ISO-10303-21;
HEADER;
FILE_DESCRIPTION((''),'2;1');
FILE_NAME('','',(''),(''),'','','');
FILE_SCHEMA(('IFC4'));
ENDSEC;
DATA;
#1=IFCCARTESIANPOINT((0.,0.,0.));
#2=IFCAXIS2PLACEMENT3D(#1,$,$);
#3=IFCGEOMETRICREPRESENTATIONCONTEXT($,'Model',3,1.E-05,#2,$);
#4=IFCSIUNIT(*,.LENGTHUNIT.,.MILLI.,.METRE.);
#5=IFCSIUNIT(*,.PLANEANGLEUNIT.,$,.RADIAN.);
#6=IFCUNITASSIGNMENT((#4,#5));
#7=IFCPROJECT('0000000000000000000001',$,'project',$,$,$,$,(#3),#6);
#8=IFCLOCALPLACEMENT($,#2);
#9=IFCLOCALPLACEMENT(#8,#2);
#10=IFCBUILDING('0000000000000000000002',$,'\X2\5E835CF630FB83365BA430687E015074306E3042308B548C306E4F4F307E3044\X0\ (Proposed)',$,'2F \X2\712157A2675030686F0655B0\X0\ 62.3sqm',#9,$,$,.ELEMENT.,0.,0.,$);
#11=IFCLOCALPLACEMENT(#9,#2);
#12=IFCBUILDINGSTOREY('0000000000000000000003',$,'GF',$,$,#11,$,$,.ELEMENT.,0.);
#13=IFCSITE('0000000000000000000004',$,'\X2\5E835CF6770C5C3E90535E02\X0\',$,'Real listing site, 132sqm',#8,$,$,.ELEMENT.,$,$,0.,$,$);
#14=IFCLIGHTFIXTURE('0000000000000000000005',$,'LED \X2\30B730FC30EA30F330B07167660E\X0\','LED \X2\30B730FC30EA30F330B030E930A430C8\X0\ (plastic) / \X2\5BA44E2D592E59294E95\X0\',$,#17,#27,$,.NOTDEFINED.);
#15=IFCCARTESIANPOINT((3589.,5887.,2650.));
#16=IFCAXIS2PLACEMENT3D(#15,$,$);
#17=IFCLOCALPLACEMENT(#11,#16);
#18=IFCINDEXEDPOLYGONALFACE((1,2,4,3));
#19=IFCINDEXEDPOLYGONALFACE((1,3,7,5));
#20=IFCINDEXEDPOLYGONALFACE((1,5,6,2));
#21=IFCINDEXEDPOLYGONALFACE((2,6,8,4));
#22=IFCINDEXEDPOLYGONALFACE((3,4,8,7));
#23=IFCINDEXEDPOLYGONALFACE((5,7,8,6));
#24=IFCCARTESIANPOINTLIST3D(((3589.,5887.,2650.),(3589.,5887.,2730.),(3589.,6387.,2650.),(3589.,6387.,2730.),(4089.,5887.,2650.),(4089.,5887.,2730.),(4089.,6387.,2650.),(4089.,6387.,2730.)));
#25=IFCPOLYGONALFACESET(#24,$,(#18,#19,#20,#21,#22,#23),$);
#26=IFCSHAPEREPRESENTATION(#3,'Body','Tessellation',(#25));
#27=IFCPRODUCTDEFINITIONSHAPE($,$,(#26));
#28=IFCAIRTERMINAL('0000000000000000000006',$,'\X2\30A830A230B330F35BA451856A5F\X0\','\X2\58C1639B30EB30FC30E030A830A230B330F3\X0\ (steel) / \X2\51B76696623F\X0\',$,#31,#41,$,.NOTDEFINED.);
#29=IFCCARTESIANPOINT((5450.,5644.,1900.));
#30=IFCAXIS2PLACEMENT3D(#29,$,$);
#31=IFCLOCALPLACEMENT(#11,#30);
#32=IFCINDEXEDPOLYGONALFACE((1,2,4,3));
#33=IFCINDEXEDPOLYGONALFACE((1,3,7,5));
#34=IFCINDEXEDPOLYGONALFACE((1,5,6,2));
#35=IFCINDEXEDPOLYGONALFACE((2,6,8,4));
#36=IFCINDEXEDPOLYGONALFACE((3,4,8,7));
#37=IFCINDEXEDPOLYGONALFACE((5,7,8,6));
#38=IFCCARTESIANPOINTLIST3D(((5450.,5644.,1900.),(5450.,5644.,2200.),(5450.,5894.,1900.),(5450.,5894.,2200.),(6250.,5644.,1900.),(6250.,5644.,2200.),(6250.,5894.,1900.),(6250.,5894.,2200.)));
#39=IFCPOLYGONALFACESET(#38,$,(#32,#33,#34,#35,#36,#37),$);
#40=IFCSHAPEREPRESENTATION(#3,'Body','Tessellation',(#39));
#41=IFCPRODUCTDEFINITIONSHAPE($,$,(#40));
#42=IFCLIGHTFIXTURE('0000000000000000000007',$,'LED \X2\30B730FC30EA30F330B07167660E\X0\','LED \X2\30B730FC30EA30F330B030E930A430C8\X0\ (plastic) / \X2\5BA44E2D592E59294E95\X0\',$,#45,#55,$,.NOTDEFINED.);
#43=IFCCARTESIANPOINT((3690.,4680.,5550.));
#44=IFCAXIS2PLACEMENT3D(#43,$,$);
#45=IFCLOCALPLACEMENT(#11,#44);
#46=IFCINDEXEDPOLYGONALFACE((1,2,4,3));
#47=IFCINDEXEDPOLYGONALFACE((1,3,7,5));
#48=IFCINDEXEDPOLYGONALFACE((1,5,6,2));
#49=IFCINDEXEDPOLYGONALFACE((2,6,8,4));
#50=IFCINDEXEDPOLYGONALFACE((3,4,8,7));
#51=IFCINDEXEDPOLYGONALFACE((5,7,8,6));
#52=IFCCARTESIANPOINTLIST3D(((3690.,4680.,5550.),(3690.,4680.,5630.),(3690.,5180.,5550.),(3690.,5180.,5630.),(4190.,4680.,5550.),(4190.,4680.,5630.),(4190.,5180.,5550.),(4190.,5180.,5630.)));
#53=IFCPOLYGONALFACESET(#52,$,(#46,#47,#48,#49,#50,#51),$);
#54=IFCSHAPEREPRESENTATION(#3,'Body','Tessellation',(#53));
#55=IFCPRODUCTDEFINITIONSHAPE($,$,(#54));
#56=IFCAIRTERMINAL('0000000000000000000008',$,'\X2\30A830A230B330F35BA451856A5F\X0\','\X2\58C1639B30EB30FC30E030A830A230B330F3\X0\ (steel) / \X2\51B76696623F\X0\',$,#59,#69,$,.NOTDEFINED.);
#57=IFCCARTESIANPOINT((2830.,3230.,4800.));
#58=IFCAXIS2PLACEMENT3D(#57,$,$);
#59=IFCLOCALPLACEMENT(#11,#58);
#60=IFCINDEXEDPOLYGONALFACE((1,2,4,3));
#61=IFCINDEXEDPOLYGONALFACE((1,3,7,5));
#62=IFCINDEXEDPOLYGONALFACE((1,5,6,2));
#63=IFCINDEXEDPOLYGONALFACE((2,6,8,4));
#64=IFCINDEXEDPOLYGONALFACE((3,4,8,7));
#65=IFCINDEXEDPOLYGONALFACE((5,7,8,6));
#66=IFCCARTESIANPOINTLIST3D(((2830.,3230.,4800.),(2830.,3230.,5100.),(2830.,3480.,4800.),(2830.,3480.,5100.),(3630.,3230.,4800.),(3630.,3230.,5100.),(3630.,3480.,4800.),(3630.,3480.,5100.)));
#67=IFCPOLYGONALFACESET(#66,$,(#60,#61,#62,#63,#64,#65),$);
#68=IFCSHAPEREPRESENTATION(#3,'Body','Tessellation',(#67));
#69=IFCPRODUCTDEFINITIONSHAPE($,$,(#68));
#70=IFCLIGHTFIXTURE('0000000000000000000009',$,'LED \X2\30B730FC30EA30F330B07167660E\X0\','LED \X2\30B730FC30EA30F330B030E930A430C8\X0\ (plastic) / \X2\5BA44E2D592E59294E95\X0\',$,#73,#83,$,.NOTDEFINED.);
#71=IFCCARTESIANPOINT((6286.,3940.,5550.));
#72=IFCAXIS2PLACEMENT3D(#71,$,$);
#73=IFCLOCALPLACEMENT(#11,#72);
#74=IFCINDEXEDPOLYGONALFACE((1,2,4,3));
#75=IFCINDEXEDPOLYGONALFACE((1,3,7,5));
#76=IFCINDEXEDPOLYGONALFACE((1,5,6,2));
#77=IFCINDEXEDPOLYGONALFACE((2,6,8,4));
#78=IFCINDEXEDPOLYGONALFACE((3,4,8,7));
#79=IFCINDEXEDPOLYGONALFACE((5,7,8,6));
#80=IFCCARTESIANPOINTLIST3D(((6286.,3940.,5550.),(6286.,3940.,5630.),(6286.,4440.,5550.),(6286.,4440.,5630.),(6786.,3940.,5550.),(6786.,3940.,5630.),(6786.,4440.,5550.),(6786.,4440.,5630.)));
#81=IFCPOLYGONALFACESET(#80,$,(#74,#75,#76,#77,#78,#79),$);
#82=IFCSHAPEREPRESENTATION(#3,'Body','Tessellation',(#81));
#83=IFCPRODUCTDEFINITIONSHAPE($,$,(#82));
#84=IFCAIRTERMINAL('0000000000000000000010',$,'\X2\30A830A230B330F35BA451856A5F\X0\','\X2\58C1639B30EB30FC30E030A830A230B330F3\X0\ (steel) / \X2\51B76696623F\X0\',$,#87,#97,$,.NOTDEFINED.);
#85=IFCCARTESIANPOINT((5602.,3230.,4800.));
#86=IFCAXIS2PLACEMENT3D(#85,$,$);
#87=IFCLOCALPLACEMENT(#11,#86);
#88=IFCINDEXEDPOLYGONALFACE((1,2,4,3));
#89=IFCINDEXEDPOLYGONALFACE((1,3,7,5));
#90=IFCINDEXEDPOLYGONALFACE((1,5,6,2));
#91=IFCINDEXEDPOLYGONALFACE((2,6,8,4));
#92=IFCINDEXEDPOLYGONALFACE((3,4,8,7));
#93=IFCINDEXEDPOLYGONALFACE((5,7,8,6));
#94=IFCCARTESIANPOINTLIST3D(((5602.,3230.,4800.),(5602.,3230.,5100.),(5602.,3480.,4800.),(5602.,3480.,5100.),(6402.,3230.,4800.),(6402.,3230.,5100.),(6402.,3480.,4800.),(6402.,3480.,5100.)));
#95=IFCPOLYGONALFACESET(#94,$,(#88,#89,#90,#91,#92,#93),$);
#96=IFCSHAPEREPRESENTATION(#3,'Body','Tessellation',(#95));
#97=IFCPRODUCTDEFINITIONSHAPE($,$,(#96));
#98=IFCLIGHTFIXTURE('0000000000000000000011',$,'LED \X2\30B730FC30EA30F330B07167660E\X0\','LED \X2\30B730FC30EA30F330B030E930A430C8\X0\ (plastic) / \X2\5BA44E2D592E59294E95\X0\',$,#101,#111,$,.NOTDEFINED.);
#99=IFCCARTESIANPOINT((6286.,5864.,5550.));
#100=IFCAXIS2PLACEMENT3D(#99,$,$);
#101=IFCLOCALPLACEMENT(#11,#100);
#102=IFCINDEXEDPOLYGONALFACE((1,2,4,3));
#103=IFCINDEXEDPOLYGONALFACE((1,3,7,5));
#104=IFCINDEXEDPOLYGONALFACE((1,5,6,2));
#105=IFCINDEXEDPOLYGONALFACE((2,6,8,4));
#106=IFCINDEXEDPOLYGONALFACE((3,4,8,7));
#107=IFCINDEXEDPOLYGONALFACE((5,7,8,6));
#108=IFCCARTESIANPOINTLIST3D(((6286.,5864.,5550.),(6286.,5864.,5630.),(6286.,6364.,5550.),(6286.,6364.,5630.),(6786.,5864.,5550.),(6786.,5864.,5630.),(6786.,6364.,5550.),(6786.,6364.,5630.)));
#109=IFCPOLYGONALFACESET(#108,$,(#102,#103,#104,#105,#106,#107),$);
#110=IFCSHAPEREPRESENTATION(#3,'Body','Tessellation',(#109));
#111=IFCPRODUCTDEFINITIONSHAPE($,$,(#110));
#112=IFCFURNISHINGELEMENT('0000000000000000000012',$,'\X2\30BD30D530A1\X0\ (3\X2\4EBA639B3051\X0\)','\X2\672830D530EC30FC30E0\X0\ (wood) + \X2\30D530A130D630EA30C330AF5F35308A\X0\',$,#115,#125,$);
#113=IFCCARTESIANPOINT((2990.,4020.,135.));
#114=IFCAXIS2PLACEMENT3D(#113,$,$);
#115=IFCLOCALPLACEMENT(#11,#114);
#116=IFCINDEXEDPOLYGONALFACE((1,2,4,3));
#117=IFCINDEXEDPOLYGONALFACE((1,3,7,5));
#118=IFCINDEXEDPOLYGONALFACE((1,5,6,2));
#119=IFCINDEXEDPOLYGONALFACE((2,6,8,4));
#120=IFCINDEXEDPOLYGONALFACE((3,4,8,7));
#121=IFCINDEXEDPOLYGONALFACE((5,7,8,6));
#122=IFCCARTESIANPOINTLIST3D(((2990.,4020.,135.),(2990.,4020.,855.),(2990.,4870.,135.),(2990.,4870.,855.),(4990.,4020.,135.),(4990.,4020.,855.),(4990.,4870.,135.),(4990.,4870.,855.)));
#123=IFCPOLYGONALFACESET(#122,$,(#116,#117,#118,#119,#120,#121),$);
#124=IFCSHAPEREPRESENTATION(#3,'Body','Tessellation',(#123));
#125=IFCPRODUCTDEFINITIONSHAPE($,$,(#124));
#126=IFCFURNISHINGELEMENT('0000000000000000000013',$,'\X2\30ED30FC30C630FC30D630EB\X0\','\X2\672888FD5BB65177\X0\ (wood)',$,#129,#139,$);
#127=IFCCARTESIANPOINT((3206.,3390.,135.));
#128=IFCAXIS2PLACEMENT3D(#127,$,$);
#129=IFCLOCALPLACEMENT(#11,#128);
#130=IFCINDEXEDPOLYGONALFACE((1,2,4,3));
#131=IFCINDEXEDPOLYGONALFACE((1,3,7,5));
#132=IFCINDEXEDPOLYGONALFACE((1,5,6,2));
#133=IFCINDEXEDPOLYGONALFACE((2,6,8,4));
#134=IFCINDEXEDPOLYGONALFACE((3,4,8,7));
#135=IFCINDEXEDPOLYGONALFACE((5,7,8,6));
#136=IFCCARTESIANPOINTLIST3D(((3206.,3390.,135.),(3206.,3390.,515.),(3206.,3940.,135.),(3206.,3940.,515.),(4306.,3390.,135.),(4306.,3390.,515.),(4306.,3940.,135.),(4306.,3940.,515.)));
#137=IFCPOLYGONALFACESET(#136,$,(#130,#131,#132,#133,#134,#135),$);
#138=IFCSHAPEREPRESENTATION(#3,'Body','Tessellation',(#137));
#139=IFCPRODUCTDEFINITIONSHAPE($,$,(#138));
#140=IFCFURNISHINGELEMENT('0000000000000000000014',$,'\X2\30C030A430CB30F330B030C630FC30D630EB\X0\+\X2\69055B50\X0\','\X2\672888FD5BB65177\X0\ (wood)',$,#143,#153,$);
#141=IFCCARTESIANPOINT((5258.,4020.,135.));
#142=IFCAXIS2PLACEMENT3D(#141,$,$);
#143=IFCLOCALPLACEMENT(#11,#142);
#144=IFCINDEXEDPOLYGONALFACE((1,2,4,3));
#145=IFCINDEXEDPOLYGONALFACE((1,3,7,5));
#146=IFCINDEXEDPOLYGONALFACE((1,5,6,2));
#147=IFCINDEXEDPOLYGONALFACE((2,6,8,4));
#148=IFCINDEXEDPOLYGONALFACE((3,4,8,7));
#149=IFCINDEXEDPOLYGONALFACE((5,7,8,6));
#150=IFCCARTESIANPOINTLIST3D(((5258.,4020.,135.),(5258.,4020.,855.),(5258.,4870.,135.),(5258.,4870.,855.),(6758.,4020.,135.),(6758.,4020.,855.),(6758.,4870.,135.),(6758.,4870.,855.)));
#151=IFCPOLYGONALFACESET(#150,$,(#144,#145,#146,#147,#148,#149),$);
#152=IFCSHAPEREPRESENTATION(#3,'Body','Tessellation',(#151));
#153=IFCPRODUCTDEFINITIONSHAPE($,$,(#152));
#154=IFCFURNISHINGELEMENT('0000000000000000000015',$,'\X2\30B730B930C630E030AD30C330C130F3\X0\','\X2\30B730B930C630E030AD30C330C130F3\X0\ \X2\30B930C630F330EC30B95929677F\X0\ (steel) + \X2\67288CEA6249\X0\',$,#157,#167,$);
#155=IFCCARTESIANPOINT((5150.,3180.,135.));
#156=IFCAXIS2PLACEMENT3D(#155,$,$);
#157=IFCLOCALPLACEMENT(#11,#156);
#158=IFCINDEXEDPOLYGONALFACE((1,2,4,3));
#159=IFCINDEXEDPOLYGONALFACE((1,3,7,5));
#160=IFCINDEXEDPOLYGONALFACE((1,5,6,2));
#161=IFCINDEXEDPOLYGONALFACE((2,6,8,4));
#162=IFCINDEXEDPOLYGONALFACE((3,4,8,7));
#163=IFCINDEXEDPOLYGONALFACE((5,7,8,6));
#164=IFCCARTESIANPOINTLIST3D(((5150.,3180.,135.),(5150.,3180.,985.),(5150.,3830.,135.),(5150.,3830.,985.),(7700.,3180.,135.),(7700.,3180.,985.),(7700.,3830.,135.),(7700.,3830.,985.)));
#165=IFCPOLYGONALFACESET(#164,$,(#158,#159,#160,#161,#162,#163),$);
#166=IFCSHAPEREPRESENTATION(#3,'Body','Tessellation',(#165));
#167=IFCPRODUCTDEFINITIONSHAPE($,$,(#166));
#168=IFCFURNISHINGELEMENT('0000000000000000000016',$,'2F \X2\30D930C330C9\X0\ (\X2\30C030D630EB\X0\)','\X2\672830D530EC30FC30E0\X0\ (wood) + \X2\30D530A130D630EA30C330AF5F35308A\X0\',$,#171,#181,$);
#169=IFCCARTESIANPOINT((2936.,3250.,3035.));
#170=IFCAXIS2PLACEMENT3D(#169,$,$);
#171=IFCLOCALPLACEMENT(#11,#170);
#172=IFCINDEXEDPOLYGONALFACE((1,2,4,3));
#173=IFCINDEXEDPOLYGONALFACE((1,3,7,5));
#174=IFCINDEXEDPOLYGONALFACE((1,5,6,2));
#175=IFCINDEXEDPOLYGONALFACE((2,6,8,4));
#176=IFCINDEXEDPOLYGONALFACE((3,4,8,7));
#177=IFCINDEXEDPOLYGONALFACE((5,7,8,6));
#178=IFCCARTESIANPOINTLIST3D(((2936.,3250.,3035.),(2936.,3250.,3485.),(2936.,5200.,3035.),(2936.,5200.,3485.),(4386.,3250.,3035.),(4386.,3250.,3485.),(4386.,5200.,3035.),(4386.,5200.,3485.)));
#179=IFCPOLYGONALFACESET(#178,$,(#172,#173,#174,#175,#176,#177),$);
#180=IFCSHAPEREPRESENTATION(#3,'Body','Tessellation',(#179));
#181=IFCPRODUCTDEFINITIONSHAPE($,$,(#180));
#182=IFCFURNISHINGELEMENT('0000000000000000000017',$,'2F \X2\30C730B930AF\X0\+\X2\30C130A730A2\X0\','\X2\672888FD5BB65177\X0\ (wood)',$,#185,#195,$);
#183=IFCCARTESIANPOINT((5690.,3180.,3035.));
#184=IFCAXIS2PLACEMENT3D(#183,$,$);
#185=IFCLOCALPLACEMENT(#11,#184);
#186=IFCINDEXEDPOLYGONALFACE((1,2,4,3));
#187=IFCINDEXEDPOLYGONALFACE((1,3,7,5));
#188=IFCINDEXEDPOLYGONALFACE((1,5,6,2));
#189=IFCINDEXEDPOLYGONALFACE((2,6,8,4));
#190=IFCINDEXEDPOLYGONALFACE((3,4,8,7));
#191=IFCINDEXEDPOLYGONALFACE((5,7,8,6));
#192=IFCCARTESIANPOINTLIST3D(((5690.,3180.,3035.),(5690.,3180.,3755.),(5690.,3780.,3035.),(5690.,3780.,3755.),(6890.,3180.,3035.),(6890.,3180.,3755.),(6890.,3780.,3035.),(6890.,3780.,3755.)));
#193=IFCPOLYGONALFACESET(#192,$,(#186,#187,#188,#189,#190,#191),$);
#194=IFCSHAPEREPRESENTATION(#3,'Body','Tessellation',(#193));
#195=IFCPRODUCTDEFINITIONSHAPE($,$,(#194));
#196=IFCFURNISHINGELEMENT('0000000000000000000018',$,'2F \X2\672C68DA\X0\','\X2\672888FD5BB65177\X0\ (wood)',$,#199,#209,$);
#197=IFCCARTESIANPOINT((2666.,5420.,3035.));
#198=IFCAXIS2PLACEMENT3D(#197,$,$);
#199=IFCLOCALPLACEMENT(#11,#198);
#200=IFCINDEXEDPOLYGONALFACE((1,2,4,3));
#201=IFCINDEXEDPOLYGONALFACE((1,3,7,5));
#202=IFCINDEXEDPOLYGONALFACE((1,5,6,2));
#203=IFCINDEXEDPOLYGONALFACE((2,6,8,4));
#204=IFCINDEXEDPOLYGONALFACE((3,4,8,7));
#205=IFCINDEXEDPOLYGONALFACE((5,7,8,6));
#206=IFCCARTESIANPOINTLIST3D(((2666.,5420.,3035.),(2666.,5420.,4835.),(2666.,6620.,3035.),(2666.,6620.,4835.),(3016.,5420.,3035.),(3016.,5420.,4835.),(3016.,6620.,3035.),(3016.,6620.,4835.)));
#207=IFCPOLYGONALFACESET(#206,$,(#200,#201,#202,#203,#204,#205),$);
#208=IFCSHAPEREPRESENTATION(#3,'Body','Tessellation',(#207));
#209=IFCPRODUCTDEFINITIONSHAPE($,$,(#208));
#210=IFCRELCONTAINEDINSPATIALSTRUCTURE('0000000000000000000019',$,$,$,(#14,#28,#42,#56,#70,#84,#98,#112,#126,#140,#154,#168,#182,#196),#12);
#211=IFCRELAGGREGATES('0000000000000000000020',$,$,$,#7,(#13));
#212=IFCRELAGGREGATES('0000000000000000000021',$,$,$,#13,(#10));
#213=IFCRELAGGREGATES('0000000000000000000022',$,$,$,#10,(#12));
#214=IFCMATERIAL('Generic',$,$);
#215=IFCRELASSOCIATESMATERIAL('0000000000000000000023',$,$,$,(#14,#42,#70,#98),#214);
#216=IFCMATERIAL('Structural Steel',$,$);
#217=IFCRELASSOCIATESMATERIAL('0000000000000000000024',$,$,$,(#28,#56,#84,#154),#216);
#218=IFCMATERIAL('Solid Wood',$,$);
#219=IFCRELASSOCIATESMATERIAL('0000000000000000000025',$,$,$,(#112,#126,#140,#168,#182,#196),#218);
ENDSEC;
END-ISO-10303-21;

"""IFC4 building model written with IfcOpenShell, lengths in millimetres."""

from ifc_helpers import new_model, si_unit, frame, frame_2d, origin, place, context, project, spatial, rectangle, extrude, material, element, save


model = new_model("IFC4")

# Units and contexts
model_context = context("Model", 3, precision=1e-05, world=origin())
ifc_project = project(units=[si_unit("LENGTHUNIT", "METRE", prefix="MILLI"), si_unit("PLANEANGLEUNIT", "RADIAN")], contexts=[model_context])

# Site, building, storey
site_placement = place(None, origin())
site = spatial("IfcSite", under=ifc_project, at=site_placement, Name="広島県尾道市", ObjectType="Real listing site, 132sqm", CompositionType="ELEMENT", RefElevation=0.0)
building_placement = place(site_placement, origin())
building = spatial("IfcBuilding", under=site, at=building_placement, Name="広島・茶室と縁側のある和の住まい (Proposed)", ObjectType="2F 無垢材と漆喰 62.3sqm", CompositionType="ELEMENT", ElevationOfRefHeight=0.0, ElevationOfTerrain=0.0)
storey_placement = place(building_placement, origin())
storey = spatial("IfcBuildingStorey", under=building, at=storey_placement, Name="GF", CompositionType="ELEMENT", Elevation=0.0)

# Shared definitions
ifc_material_1 = material(Name="Solid Wood")

# Shared definitions
ifc_material_2 = material(Name="Structural Steel")

# Shared definitions
ifc_material_3 = material(Name="Generic")

# Light fixture
light_fixture_1_placement = place(storey_placement, frame((3589.0, 5887.0, 2650.0)))
element("IfcLightFixture", 1, at=light_fixture_1_placement, inside=storey, material=ifc_material_3, Name="LED シーリング照明", Description="LED シーリングライト (plastic) / 室中央天井", PredefinedType="NOTDEFINED", context=model_context, shape_type="SweptSolid", body=[
    extrude(rectangle(XDim=500.0, YDim=500.0, at=frame_2d((250.0, 250.0))), frame((3589.0, 5887.0, 2650.0)), (0.0, 0.0, 1.0), 80.0),
])

# Air terminal
air_terminal_1_placement = place(storey_placement, frame((5450.0, 5644.0, 1900.0)))
element("IfcAirTerminal", 2, at=air_terminal_1_placement, inside=storey, material=ifc_material_2, Name="エアコン室内機", Description="壁掛ルームエアコン (steel) / 冷暖房", PredefinedType="NOTDEFINED", context=model_context, shape_type="SweptSolid", body=[
    extrude(rectangle(XDim=800.0, YDim=250.0, at=frame_2d((400.0, 125.0))), frame((5450.0, 5644.0, 1900.0)), (0.0, 0.0, 1.0), 300.0),
])

# Light fixture
light_fixture_2_placement = place(storey_placement, frame((3690.0, 4680.0, 5550.0)))
element("IfcLightFixture", 3, at=light_fixture_2_placement, inside=storey, material=ifc_material_3, Name="LED シーリング照明", Description="LED シーリングライト (plastic) / 室中央天井", PredefinedType="NOTDEFINED", context=model_context, shape_type="SweptSolid", body=[
    extrude(rectangle(XDim=500.0, YDim=500.0, at=frame_2d((250.0, 250.0))), frame((3690.0, 4680.0, 5550.0)), (0.0, 0.0, 1.0), 80.0),
])

# Air terminal
air_terminal_2_placement = place(storey_placement, frame((2830.0, 3230.0, 4800.0)))
element("IfcAirTerminal", 4, at=air_terminal_2_placement, inside=storey, material=ifc_material_2, Name="エアコン室内機", Description="壁掛ルームエアコン (steel) / 冷暖房", PredefinedType="NOTDEFINED", context=model_context, shape_type="SweptSolid", body=[
    extrude(rectangle(XDim=800.0, YDim=250.0, at=frame_2d((400.0, 125.0))), frame((2830.0, 3230.0, 4800.0)), (0.0, 0.0, 1.0), 300.0),
])

# Light fixture
light_fixture_3_placement = place(storey_placement, frame((6286.0, 3940.0, 5550.0)))
element("IfcLightFixture", 5, at=light_fixture_3_placement, inside=storey, material=ifc_material_3, Name="LED シーリング照明", Description="LED シーリングライト (plastic) / 室中央天井", PredefinedType="NOTDEFINED", context=model_context, shape_type="SweptSolid", body=[
    extrude(rectangle(XDim=500.0, YDim=500.0, at=frame_2d((250.0, 250.0))), frame((6286.0, 3940.0, 5550.0)), (0.0, 0.0, 1.0), 80.0),
])

# Air terminal
air_terminal_3_placement = place(storey_placement, frame((5602.0, 3230.0, 4800.0)))
element("IfcAirTerminal", 6, at=air_terminal_3_placement, inside=storey, material=ifc_material_2, Name="エアコン室内機", Description="壁掛ルームエアコン (steel) / 冷暖房", PredefinedType="NOTDEFINED", context=model_context, shape_type="SweptSolid", body=[
    extrude(rectangle(XDim=800.0, YDim=250.0, at=frame_2d((400.0, 125.0))), frame((5602.0, 3230.0, 4800.0)), (0.0, 0.0, 1.0), 300.0),
])

# Light fixture
light_fixture_4_placement = place(storey_placement, frame((6286.0, 5864.0, 5550.0)))
element("IfcLightFixture", 7, at=light_fixture_4_placement, inside=storey, material=ifc_material_3, Name="LED シーリング照明", Description="LED シーリングライト (plastic) / 室中央天井", PredefinedType="NOTDEFINED", context=model_context, shape_type="SweptSolid", body=[
    extrude(rectangle(XDim=500.0, YDim=500.0, at=frame_2d((250.0, 250.0))), frame((6286.0, 5864.0, 5550.0)), (0.0, 0.0, 1.0), 80.0),
])

# Furnishing elements
furnishing_1_placement = place(storey_placement, frame((2990.0, 4020.0, 135.0)))
element("IfcFurnishingElement", 8, at=furnishing_1_placement, inside=storey, material=ifc_material_1, Name="ソファ (3人掛け)", Description="木フレーム (wood) + ファブリック張り", context=model_context, shape_type="SweptSolid", body=[
    extrude(rectangle(XDim=2000.0, YDim=850.0, at=frame_2d((1000.0, 425.0))), frame((2990.0, 4020.0, 135.0)), (0.0, 0.0, 1.0), 720.0),
])
furnishing_2_placement = place(storey_placement, frame((3206.0, 3390.0, 135.0)))
element("IfcFurnishingElement", 9, at=furnishing_2_placement, inside=storey, material=ifc_material_1, Name="ローテーブル", Description="木製家具 (wood)", context=model_context, shape_type="SweptSolid", body=[
    extrude(rectangle(XDim=1100.0, YDim=550.0, at=frame_2d((550.0, 275.0))), frame((3206.0, 3390.0, 135.0)), (0.0, 0.0, 1.0), 380.0),
])
furnishing_3_placement = place(storey_placement, frame((5258.0, 4020.0, 135.0)))
element("IfcFurnishingElement", 10, at=furnishing_3_placement, inside=storey, material=ifc_material_1, Name="ダイニングテーブル+椅子", Description="木製家具 (wood)", context=model_context, shape_type="SweptSolid", body=[
    extrude(rectangle(XDim=1500.0, YDim=850.0, at=frame_2d((750.0, 425.0))), frame((5258.0, 4020.0, 135.0)), (0.0, 0.0, 1.0), 720.0),
])
furnishing_4_placement = place(storey_placement, frame((5150.0, 3180.0, 135.0)))
element("IfcFurnishingElement", 11, at=furnishing_4_placement, inside=storey, material=ifc_material_2, Name="システムキッチン", Description="システムキッチン ステンレス天板 (steel) + 木質扉", context=model_context, shape_type="SweptSolid", body=[
    extrude(rectangle(XDim=2550.0, YDim=650.0, at=frame_2d((1275.0, 325.0))), frame((5150.0, 3180.0, 135.0)), (0.0, 0.0, 1.0), 850.0),
])
furnishing_5_placement = place(storey_placement, frame((2936.0, 3250.0, 3035.0)))
element("IfcFurnishingElement", 12, at=furnishing_5_placement, inside=storey, material=ifc_material_1, Name="2F ベッド (ダブル)", Description="木フレーム (wood) + ファブリック張り", context=model_context, shape_type="SweptSolid", body=[
    extrude(rectangle(XDim=1450.0, YDim=1950.0, at=frame_2d((725.0, 975.0))), frame((2936.0, 3250.0, 3035.0)), (0.0, 0.0, 1.0), 450.0),
])
furnishing_6_placement = place(storey_placement, frame((5690.0, 3180.0, 3035.0)))
element("IfcFurnishingElement", 13, at=furnishing_6_placement, inside=storey, material=ifc_material_1, Name="2F デスク+チェア", Description="木製家具 (wood)", context=model_context, shape_type="SweptSolid", body=[
    extrude(rectangle(XDim=1200.0, YDim=600.0, at=frame_2d((600.0, 300.0))), frame((5690.0, 3180.0, 3035.0)), (0.0, 0.0, 1.0), 720.0),
])
furnishing_7_placement = place(storey_placement, frame((2666.0, 5420.0, 3035.0)))
element("IfcFurnishingElement", 14, at=furnishing_7_placement, inside=storey, material=ifc_material_1, Name="2F 本棚", Description="木製家具 (wood)", context=model_context, shape_type="SweptSolid", body=[
    extrude(rectangle(XDim=350.0, YDim=1200.0, at=frame_2d((175.0, 600.0))), frame((2666.0, 5420.0, 3035.0)), (0.0, 0.0, 1.0), 1800.0),
])

save(model, "model.ifc")
